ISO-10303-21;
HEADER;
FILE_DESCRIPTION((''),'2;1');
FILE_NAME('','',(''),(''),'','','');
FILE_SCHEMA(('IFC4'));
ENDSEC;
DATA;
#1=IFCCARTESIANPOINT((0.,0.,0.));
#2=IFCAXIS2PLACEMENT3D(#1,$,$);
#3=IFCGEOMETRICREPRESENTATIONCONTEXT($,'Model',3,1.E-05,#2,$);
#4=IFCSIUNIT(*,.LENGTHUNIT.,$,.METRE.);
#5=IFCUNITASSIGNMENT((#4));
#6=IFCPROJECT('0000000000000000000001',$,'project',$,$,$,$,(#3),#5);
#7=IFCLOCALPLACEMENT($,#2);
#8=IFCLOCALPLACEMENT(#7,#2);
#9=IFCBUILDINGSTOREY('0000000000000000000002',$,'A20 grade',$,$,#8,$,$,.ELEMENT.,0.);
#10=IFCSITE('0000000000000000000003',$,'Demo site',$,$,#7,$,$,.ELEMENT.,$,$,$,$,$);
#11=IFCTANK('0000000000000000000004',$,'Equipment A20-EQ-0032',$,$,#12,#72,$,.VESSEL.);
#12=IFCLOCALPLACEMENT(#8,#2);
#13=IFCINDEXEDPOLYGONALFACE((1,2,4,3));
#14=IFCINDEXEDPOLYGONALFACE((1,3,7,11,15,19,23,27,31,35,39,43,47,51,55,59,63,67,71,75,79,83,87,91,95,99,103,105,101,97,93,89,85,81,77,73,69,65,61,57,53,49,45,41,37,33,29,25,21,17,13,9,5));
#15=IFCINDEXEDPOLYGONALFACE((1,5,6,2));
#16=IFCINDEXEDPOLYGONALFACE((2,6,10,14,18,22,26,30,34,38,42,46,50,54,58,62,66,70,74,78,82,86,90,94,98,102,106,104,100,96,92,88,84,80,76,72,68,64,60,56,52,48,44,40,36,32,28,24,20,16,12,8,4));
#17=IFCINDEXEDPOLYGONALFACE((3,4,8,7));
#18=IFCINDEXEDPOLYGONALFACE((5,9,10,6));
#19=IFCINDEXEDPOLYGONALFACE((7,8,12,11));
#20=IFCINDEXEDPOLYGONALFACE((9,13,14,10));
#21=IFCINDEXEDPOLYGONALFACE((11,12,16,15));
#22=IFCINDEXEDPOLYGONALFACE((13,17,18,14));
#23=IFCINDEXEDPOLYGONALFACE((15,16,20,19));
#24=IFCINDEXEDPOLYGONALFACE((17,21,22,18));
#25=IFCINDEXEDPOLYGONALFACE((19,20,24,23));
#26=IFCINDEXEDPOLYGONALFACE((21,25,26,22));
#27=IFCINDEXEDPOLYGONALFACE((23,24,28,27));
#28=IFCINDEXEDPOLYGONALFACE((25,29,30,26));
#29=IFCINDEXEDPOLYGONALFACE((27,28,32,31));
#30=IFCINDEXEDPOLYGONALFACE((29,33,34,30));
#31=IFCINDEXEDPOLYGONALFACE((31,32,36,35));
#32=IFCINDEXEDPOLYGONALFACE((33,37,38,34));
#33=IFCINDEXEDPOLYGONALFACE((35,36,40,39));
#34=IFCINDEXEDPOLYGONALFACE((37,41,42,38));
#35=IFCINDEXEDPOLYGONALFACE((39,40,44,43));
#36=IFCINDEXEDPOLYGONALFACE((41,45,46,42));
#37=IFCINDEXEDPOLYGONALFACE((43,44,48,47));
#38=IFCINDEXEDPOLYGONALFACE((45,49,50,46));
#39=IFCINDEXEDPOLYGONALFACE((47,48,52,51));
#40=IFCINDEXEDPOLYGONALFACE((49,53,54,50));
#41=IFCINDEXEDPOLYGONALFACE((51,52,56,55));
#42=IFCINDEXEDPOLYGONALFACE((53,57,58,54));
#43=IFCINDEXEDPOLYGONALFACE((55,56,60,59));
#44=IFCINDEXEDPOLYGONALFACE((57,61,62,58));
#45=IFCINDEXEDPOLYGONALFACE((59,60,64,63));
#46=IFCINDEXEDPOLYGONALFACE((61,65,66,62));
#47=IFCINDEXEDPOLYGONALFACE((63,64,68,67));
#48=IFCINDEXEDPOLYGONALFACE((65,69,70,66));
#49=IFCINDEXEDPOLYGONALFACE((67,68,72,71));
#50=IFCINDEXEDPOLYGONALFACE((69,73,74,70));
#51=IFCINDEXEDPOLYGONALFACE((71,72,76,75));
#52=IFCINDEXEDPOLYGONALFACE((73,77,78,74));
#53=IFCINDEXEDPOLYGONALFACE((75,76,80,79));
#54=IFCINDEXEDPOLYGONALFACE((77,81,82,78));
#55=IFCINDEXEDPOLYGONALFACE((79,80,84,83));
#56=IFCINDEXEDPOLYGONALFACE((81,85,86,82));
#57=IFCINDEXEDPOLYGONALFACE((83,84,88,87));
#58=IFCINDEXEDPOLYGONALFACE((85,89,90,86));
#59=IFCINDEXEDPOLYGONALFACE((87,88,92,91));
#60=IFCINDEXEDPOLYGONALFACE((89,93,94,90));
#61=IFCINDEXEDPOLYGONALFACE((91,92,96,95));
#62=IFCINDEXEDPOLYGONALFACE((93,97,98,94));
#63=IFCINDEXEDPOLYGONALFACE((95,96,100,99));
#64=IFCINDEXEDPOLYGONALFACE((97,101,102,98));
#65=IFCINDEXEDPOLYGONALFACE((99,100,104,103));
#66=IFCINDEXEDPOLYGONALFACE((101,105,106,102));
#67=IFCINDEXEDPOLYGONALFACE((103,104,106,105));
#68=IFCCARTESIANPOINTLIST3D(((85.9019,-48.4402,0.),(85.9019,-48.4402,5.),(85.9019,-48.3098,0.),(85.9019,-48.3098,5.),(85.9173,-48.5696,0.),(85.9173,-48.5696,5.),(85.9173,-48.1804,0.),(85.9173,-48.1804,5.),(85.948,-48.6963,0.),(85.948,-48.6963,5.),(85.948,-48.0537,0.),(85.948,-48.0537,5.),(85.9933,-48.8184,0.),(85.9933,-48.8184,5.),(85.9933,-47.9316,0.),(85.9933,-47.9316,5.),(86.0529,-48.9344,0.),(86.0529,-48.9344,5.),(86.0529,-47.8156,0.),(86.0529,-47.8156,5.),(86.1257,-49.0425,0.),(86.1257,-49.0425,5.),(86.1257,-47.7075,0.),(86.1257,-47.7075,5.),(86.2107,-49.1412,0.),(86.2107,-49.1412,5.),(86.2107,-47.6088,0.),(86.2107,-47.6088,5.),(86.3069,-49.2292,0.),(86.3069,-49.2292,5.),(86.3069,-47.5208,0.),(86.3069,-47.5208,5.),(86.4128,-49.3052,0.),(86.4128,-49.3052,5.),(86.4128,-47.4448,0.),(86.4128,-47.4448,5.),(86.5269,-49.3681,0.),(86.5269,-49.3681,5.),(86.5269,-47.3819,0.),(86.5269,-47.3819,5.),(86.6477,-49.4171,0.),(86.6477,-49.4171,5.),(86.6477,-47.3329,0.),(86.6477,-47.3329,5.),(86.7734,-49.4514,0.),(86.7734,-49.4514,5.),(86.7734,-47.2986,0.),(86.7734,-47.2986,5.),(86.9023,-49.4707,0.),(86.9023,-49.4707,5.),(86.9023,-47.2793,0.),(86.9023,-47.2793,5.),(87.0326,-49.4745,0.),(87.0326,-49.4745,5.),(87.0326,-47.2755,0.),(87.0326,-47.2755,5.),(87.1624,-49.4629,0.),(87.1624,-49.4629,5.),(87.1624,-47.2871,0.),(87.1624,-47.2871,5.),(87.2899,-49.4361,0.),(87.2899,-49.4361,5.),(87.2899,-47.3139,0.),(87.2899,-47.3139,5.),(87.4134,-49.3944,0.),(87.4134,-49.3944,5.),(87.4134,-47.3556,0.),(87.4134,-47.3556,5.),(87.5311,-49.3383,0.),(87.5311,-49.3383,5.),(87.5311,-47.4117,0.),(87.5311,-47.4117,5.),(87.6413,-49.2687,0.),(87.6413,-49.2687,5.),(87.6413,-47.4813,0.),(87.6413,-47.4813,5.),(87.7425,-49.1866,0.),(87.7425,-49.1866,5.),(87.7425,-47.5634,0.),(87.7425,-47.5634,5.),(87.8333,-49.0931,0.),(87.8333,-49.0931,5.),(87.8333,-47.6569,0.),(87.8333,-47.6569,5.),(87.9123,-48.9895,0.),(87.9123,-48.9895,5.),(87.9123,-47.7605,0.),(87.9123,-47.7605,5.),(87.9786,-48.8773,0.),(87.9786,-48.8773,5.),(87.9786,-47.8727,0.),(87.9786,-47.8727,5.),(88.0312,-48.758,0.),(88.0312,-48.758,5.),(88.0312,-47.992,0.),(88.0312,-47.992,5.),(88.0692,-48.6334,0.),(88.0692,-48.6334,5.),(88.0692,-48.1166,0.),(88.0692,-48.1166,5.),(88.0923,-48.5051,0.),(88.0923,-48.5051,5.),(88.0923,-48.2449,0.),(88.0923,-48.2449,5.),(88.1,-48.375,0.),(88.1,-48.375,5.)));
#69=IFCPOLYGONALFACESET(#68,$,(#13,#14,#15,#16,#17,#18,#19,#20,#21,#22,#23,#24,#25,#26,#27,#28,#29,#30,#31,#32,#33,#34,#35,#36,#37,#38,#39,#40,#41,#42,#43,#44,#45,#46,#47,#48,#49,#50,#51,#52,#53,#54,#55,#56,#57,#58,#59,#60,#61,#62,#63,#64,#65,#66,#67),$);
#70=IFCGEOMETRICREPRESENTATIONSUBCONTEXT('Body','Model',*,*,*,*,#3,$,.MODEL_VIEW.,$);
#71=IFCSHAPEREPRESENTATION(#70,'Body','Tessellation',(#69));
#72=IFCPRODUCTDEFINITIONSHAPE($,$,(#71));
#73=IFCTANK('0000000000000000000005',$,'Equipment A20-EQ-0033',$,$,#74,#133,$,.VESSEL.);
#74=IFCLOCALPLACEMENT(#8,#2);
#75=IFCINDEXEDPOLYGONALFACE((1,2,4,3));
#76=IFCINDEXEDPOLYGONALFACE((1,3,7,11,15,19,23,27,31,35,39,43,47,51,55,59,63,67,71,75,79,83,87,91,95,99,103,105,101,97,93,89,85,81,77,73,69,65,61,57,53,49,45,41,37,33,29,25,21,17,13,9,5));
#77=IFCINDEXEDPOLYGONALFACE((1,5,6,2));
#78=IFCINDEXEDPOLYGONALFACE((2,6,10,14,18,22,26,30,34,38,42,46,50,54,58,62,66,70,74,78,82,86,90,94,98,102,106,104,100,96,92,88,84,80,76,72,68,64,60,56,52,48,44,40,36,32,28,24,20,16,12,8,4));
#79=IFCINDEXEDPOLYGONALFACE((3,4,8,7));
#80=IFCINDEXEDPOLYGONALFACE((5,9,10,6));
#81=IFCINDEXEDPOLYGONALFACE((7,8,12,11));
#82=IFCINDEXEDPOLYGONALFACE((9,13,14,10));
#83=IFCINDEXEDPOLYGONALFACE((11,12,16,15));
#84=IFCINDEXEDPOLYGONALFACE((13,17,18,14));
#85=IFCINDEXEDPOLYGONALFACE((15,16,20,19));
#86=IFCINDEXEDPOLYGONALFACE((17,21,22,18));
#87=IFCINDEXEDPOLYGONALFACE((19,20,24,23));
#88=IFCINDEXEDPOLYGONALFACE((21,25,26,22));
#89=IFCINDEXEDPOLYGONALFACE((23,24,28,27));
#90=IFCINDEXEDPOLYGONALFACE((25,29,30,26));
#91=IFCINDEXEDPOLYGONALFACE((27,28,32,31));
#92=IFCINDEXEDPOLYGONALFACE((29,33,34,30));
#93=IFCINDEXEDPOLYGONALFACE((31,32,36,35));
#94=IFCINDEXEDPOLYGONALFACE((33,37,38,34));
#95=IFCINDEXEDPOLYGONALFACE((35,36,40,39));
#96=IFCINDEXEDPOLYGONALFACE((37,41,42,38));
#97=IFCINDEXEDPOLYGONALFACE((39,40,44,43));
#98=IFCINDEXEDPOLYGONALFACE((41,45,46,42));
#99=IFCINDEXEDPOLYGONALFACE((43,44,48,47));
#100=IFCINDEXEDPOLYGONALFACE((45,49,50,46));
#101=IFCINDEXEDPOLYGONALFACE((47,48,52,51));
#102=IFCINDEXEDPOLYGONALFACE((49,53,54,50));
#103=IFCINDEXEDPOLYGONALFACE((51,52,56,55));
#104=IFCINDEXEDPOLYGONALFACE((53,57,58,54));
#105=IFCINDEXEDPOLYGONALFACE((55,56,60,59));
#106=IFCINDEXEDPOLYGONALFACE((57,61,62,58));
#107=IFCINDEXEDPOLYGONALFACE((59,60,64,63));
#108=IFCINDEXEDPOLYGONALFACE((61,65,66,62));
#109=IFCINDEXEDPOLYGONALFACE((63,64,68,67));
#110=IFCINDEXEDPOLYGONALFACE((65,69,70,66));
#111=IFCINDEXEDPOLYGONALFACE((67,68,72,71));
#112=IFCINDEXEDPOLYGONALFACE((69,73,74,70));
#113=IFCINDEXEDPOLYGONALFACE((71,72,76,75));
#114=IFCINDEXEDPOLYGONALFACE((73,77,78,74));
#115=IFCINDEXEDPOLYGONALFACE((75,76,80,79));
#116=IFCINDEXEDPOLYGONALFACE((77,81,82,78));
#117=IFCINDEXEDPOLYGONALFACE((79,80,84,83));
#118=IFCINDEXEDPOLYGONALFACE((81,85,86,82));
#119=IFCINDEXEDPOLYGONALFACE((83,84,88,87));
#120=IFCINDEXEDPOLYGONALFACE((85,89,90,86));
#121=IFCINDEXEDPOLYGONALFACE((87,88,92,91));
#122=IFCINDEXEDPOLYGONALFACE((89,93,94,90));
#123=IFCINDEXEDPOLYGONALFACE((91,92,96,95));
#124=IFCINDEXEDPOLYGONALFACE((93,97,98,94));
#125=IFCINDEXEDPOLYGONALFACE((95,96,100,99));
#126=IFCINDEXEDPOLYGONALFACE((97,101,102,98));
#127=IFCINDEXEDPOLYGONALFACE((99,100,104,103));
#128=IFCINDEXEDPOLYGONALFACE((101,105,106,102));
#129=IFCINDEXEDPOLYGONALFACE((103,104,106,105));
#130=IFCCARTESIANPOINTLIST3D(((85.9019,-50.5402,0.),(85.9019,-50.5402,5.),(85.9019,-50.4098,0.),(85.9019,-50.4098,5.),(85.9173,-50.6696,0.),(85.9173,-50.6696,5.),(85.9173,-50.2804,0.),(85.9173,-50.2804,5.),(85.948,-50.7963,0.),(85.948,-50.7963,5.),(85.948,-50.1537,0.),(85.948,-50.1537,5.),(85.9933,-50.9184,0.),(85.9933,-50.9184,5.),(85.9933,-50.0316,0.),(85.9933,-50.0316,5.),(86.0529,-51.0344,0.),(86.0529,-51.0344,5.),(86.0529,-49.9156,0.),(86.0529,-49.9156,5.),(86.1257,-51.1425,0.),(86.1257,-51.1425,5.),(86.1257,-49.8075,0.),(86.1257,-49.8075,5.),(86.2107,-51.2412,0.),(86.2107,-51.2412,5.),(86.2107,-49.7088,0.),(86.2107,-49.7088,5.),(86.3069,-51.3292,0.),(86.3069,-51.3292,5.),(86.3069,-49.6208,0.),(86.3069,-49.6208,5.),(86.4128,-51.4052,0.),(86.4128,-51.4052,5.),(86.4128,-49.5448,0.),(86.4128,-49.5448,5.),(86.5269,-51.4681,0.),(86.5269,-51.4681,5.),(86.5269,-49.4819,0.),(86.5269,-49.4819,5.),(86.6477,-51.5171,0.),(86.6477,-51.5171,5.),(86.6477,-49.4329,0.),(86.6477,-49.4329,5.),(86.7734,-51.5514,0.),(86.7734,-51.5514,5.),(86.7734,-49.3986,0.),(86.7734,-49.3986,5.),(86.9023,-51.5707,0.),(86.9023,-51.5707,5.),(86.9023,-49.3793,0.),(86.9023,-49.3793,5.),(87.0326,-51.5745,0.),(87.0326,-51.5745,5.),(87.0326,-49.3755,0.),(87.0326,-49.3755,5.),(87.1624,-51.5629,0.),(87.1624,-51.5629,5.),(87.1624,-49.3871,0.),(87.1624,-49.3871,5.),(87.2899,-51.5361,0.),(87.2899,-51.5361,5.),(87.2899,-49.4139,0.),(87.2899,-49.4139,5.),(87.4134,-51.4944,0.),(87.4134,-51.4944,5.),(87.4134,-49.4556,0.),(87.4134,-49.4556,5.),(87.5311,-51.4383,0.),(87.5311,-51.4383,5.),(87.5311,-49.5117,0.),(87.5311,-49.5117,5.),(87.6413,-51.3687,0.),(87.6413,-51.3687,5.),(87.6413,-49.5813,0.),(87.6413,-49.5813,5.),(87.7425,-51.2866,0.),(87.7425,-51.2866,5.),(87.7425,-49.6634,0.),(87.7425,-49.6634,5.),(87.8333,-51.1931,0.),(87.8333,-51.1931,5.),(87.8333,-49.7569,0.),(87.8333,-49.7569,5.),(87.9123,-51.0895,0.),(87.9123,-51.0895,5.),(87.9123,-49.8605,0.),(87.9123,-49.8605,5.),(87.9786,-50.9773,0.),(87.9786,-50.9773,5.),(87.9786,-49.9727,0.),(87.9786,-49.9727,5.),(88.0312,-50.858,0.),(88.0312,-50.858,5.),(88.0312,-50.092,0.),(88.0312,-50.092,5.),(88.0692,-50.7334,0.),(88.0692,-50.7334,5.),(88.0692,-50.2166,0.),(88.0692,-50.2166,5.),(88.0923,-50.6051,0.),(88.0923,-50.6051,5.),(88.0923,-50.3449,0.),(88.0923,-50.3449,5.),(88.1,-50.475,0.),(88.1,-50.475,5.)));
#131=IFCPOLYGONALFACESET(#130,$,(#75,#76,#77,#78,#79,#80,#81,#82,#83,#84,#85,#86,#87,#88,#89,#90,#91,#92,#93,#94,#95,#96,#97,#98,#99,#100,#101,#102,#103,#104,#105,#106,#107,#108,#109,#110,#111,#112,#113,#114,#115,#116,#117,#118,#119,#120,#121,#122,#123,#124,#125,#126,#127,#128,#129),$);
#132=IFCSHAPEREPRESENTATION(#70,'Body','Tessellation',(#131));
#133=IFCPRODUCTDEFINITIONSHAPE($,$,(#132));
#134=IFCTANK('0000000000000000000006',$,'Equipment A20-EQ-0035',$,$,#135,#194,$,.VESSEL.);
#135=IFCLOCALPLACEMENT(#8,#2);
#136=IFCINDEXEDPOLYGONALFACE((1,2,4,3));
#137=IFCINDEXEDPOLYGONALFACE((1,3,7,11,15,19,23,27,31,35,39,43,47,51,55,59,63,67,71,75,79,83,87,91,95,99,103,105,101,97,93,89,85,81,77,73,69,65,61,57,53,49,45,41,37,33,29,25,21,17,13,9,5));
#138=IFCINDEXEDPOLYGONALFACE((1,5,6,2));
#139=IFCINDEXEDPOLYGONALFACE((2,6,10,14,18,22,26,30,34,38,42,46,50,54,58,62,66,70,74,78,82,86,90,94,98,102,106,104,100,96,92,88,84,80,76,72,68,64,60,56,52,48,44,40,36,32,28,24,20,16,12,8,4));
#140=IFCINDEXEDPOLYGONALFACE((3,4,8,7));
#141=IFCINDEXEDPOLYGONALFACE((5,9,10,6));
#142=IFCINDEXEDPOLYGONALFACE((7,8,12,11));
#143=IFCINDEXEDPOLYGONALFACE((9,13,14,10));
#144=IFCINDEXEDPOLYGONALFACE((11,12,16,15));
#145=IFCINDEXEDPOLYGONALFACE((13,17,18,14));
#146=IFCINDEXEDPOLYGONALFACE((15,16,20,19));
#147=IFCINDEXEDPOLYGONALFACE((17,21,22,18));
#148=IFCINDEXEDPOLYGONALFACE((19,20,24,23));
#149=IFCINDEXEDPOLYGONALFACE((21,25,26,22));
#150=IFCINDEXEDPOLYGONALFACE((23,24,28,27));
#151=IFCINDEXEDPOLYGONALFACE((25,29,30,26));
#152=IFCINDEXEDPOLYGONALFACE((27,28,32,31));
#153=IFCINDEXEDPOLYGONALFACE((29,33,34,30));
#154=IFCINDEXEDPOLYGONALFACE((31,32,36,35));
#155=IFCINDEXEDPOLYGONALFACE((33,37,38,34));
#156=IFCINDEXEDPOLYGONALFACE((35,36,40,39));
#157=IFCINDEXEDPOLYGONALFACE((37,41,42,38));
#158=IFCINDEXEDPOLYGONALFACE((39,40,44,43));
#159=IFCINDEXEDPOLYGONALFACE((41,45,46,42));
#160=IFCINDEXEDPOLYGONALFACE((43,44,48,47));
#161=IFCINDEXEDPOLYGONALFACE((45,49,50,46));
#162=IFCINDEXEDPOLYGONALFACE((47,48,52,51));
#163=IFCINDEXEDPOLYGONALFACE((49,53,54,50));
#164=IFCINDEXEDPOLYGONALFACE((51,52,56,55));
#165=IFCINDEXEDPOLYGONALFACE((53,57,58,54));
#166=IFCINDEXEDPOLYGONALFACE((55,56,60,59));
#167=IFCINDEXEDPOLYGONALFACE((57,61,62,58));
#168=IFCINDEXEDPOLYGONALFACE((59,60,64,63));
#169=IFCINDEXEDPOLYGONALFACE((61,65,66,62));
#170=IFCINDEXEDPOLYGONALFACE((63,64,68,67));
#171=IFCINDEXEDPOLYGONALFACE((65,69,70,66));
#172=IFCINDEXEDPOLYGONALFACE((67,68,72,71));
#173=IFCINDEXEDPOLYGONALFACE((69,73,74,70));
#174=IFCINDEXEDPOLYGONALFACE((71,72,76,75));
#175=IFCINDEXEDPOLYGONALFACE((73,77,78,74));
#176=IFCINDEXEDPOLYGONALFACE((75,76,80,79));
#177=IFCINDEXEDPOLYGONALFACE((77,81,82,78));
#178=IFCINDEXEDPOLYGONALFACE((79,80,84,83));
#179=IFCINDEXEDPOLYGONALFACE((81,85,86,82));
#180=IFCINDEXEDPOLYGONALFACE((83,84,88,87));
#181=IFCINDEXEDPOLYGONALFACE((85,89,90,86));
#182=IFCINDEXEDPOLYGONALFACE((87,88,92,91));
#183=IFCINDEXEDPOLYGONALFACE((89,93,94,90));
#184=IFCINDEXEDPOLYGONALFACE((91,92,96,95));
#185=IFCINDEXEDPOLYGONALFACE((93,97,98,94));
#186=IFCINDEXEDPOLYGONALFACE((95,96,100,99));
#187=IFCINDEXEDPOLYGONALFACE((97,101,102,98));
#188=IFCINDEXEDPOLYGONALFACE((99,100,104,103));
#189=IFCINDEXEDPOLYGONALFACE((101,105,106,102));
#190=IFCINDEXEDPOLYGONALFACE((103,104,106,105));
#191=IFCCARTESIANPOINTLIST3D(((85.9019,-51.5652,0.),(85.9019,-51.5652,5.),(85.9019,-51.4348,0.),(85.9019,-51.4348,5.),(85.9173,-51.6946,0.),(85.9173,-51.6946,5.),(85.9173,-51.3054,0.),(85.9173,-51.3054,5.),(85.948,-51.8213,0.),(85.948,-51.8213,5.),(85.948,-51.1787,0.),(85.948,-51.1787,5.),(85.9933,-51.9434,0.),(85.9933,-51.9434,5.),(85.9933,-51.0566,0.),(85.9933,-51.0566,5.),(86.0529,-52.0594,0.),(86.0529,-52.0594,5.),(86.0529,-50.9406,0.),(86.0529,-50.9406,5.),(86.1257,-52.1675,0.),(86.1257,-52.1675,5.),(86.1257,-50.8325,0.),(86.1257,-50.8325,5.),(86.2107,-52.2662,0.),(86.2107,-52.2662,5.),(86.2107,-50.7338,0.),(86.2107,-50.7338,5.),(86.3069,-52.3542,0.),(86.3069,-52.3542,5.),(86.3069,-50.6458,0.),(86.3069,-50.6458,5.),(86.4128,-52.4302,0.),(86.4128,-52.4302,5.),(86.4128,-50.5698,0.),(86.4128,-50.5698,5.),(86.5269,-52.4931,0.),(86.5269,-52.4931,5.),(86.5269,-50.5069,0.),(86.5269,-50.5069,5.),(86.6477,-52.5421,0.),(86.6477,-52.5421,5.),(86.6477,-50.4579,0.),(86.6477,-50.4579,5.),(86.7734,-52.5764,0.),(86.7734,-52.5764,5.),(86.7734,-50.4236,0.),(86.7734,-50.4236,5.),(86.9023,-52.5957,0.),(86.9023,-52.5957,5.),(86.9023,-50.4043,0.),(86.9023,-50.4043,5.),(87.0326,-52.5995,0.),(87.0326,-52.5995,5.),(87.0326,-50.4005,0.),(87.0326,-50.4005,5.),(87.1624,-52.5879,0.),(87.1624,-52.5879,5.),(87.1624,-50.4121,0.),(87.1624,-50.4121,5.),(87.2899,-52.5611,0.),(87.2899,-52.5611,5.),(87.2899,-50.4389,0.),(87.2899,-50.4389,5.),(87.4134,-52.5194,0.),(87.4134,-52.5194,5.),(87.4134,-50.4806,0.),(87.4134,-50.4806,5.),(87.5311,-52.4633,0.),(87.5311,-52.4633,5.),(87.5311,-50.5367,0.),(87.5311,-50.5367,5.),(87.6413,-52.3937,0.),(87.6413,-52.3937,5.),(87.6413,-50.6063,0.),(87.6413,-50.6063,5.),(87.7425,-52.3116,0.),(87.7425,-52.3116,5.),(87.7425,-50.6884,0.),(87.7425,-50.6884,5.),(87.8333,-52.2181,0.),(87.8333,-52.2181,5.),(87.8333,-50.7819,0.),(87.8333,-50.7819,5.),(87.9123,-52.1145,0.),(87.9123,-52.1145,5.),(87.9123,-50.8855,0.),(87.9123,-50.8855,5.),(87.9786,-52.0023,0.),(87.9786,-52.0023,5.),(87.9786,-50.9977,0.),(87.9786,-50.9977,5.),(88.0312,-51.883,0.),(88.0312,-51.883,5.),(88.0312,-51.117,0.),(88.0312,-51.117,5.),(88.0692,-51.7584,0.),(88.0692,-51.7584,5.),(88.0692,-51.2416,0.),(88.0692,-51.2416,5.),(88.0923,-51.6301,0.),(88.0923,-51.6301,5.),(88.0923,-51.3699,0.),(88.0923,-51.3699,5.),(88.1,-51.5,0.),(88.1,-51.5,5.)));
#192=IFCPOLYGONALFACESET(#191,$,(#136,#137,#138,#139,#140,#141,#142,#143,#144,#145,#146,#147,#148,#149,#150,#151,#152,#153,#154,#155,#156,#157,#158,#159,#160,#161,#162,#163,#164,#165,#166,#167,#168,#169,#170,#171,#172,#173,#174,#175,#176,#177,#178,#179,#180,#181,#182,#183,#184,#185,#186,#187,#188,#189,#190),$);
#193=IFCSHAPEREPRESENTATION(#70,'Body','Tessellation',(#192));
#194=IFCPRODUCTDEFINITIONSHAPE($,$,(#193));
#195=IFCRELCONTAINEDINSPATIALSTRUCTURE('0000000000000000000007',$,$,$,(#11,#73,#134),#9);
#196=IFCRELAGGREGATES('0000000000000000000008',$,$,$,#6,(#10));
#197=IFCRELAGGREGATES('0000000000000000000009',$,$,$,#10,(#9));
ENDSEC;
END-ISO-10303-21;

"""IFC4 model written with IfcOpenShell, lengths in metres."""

from ifc_helpers import new_model, si_unit, frame, origin, place, context, subcontext, project, spatial, circle, extrude, element, save


model = new_model("IFC4")

# Units and contexts
model_context = context("Model", 3, precision=1e-05, world=origin())
body_context = subcontext(model_context, "Body", "Model", "MODEL_VIEW")
ifc_project = project(units=[si_unit("LENGTHUNIT", "METRE")], contexts=[model_context])

# Site, storey
site_placement = place(None, origin())
site = spatial("IfcSite", under=ifc_project, at=site_placement, Name="Demo site", CompositionType="ELEMENT")
storey_placement = place(site_placement, origin())
storey = spatial("IfcBuildingStorey", under=site, at=storey_placement, Name="A20 grade", CompositionType="ELEMENT", Elevation=0.0)

# Tanks
for number, where, name in (
    (1, (87.0, -48.375, 0.0), "Equipment A20-EQ-0032"),
    (2, (87.0, -50.475, 0.0), "Equipment A20-EQ-0033"),
    (3, (87.0, -51.5, 0.0), "Equipment A20-EQ-0035"),
):
    element("IfcTank", number, at=place(storey_placement, frame(where)), inside=storey, Name=name, PredefinedType="VESSEL", context=body_context, shape_type="SweptSolid", body=[
        extrude(circle(Radius=1.1), origin(), (0.0, 0.0, 1.0), 5.0),
    ])

save(model, "model.ifc")
